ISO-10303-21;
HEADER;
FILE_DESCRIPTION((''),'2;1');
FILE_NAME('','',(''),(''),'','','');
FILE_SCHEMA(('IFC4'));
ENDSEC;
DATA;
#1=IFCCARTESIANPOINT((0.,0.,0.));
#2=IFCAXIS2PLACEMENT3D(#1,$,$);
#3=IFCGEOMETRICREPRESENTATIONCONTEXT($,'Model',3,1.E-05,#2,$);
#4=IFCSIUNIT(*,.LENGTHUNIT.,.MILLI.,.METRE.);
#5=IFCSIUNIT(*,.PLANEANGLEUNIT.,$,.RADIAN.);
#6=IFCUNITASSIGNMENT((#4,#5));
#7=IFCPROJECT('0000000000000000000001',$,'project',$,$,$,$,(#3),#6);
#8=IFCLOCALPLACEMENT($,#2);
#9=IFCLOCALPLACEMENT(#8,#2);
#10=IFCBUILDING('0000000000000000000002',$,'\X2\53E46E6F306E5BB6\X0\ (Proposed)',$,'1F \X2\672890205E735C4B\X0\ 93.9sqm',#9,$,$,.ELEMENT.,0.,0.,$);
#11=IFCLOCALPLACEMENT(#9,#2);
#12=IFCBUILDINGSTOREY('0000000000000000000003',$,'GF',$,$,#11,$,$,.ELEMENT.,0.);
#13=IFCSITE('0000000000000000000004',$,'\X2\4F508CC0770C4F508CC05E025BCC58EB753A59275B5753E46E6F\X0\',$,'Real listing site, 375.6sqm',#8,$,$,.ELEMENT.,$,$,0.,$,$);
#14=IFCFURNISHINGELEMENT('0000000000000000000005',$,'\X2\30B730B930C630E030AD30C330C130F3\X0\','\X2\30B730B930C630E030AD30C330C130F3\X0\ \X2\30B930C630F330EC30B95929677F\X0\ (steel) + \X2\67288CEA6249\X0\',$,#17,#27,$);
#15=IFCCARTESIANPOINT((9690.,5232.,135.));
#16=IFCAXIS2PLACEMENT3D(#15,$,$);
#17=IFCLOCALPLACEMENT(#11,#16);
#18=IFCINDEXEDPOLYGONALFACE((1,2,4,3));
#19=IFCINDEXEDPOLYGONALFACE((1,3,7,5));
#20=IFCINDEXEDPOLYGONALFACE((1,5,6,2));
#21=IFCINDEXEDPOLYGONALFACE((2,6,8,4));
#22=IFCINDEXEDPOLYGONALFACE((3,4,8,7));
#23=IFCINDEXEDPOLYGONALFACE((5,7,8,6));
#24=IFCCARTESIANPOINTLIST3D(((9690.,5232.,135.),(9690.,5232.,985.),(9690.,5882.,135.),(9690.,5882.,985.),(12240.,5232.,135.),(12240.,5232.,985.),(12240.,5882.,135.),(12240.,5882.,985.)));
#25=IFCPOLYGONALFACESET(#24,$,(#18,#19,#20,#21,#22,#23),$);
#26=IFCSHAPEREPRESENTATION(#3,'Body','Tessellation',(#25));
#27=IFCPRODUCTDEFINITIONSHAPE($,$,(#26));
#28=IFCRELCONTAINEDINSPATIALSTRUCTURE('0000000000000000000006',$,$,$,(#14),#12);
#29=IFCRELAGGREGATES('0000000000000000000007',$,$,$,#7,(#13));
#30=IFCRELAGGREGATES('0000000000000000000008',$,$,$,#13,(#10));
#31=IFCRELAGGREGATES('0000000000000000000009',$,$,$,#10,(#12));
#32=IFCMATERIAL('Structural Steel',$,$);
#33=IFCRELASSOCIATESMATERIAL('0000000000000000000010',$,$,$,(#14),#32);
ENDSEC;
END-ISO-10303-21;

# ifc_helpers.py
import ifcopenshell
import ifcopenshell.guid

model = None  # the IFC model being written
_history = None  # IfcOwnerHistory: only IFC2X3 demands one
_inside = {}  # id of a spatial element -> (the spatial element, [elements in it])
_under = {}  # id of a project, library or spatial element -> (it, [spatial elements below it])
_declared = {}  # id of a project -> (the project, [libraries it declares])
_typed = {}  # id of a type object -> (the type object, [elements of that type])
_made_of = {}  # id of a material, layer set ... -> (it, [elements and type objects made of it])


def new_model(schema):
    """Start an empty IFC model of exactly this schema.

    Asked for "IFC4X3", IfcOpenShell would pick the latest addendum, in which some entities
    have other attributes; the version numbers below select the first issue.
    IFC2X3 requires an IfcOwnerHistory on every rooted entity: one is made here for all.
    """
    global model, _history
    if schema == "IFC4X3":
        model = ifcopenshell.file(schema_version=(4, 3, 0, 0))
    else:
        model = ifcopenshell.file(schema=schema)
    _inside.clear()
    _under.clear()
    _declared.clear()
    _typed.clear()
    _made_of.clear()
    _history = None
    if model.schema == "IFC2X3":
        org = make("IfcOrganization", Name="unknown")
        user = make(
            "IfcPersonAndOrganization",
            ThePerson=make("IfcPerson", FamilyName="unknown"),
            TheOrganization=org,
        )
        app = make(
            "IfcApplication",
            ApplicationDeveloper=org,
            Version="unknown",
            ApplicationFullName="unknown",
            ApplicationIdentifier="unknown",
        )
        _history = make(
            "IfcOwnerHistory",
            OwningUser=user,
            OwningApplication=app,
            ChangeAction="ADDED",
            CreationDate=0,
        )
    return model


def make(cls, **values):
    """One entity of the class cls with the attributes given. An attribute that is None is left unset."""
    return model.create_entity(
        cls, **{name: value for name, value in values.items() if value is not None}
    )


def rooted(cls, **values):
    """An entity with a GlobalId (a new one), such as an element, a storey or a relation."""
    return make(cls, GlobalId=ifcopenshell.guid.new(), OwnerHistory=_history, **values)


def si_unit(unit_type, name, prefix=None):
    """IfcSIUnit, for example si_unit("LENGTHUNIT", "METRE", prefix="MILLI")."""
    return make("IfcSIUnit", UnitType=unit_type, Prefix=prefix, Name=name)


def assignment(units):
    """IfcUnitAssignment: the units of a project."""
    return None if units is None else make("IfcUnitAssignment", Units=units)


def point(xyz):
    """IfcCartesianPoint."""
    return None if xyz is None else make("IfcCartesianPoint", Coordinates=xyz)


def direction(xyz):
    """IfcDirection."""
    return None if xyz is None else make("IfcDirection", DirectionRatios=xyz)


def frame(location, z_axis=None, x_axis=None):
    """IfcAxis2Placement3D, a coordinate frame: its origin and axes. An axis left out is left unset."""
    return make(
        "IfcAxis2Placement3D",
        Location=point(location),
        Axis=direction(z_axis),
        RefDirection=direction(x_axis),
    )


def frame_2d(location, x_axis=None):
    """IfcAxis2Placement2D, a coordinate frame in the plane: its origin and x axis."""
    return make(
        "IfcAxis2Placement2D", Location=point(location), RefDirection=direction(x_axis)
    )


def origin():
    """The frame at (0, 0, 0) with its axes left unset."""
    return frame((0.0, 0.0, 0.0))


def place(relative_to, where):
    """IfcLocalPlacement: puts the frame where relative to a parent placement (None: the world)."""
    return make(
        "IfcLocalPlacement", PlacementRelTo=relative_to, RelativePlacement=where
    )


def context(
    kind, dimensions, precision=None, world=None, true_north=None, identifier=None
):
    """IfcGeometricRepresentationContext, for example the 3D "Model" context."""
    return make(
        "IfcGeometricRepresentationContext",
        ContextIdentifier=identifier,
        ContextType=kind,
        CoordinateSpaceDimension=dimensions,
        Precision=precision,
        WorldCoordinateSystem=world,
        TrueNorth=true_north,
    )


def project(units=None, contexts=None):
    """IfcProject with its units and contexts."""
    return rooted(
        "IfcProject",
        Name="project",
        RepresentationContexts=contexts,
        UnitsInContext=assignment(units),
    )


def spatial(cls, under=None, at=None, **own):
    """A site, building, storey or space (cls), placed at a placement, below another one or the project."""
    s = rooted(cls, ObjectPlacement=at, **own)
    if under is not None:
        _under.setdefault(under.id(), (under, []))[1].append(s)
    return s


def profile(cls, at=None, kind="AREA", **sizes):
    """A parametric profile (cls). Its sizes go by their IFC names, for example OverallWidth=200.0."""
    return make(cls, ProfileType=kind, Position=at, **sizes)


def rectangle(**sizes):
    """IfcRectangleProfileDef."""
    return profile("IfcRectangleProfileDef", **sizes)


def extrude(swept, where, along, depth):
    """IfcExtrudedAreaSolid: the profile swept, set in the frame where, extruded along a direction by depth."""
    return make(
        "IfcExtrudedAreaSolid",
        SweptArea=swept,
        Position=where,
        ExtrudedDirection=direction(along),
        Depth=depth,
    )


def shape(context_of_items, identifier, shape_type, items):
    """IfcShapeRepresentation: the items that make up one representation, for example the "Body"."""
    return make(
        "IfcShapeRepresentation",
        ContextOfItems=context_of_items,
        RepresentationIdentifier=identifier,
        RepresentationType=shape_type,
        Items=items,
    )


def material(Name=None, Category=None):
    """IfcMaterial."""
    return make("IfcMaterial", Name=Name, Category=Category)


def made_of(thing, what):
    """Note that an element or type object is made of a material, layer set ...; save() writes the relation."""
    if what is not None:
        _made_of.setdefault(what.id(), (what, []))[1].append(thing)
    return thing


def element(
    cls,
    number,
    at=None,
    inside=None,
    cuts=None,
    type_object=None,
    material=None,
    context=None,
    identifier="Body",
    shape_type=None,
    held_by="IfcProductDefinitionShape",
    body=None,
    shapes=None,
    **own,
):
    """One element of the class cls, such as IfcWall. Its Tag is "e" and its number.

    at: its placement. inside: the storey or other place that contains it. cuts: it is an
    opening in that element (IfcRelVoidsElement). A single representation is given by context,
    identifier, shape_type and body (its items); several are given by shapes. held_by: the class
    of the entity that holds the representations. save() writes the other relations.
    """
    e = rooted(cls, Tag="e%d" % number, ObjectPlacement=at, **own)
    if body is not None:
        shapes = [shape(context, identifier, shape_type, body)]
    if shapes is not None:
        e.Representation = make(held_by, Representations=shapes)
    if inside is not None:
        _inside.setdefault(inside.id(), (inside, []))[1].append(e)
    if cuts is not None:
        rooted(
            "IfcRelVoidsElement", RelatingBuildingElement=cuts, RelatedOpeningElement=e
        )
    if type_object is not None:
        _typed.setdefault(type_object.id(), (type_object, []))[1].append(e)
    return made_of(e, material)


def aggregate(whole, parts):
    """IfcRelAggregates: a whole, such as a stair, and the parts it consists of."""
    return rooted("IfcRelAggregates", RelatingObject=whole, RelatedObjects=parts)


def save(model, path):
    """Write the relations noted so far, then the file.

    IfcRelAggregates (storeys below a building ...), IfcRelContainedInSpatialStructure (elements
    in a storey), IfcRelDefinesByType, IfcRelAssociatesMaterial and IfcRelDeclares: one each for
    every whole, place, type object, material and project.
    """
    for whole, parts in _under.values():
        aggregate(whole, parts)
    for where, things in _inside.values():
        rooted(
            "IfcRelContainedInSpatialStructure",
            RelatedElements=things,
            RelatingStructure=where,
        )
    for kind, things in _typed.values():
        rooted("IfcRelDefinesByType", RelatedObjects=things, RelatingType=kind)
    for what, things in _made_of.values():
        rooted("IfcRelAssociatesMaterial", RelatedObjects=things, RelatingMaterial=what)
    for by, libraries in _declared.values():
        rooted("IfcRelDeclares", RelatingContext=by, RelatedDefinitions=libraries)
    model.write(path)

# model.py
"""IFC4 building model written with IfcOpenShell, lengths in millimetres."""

from ifc_helpers import new_model, si_unit, frame, frame_2d, origin, place, context, project, spatial, rectangle, extrude, material, element, save


model = new_model("IFC4")

# Units and contexts
model_context = context("Model", 3, precision=1e-05, world=origin())
ifc_project = project(units=[si_unit("LENGTHUNIT", "METRE", prefix="MILLI"), si_unit("PLANEANGLEUNIT", "RADIAN")], contexts=[model_context])

# Site, building, storey
site_placement = place(None, origin())
site = spatial("IfcSite", under=ifc_project, at=site_placement, Name="佐賀県佐賀市富士町大字古湯", ObjectType="Real listing site, 375.6sqm", CompositionType="ELEMENT", RefElevation=0.0)
building_placement = place(site_placement, origin())
building = spatial("IfcBuilding", under=site, at=building_placement, Name="古湯の家 (Proposed)", ObjectType="1F 木造平屋 93.9sqm", CompositionType="ELEMENT", ElevationOfRefHeight=0.0, ElevationOfTerrain=0.0)
storey_placement = place(building_placement, origin())
storey = spatial("IfcBuildingStorey", under=building, at=storey_placement, Name="GF", CompositionType="ELEMENT", Elevation=0.0)

# Shared definitions
ifc_material_1 = material(Name="Structural Steel")

# Furnishing element
furnishing_1_placement = place(storey_placement, frame((9690.0, 5232.0, 135.0)))
element("IfcFurnishingElement", 1, at=furnishing_1_placement, inside=storey, material=ifc_material_1, Name="システムキッチン", Description="システムキッチン ステンレス天板 (steel) + 木質扉", context=model_context, shape_type="SweptSolid", body=[
    extrude(rectangle(XDim=2550.0, YDim=650.0, at=frame_2d((1275.0, 325.0))), frame((9690.0, 5232.0, 135.0)), (0.0, 0.0, 1.0), 850.0),
])

save(model, "model.ifc")
